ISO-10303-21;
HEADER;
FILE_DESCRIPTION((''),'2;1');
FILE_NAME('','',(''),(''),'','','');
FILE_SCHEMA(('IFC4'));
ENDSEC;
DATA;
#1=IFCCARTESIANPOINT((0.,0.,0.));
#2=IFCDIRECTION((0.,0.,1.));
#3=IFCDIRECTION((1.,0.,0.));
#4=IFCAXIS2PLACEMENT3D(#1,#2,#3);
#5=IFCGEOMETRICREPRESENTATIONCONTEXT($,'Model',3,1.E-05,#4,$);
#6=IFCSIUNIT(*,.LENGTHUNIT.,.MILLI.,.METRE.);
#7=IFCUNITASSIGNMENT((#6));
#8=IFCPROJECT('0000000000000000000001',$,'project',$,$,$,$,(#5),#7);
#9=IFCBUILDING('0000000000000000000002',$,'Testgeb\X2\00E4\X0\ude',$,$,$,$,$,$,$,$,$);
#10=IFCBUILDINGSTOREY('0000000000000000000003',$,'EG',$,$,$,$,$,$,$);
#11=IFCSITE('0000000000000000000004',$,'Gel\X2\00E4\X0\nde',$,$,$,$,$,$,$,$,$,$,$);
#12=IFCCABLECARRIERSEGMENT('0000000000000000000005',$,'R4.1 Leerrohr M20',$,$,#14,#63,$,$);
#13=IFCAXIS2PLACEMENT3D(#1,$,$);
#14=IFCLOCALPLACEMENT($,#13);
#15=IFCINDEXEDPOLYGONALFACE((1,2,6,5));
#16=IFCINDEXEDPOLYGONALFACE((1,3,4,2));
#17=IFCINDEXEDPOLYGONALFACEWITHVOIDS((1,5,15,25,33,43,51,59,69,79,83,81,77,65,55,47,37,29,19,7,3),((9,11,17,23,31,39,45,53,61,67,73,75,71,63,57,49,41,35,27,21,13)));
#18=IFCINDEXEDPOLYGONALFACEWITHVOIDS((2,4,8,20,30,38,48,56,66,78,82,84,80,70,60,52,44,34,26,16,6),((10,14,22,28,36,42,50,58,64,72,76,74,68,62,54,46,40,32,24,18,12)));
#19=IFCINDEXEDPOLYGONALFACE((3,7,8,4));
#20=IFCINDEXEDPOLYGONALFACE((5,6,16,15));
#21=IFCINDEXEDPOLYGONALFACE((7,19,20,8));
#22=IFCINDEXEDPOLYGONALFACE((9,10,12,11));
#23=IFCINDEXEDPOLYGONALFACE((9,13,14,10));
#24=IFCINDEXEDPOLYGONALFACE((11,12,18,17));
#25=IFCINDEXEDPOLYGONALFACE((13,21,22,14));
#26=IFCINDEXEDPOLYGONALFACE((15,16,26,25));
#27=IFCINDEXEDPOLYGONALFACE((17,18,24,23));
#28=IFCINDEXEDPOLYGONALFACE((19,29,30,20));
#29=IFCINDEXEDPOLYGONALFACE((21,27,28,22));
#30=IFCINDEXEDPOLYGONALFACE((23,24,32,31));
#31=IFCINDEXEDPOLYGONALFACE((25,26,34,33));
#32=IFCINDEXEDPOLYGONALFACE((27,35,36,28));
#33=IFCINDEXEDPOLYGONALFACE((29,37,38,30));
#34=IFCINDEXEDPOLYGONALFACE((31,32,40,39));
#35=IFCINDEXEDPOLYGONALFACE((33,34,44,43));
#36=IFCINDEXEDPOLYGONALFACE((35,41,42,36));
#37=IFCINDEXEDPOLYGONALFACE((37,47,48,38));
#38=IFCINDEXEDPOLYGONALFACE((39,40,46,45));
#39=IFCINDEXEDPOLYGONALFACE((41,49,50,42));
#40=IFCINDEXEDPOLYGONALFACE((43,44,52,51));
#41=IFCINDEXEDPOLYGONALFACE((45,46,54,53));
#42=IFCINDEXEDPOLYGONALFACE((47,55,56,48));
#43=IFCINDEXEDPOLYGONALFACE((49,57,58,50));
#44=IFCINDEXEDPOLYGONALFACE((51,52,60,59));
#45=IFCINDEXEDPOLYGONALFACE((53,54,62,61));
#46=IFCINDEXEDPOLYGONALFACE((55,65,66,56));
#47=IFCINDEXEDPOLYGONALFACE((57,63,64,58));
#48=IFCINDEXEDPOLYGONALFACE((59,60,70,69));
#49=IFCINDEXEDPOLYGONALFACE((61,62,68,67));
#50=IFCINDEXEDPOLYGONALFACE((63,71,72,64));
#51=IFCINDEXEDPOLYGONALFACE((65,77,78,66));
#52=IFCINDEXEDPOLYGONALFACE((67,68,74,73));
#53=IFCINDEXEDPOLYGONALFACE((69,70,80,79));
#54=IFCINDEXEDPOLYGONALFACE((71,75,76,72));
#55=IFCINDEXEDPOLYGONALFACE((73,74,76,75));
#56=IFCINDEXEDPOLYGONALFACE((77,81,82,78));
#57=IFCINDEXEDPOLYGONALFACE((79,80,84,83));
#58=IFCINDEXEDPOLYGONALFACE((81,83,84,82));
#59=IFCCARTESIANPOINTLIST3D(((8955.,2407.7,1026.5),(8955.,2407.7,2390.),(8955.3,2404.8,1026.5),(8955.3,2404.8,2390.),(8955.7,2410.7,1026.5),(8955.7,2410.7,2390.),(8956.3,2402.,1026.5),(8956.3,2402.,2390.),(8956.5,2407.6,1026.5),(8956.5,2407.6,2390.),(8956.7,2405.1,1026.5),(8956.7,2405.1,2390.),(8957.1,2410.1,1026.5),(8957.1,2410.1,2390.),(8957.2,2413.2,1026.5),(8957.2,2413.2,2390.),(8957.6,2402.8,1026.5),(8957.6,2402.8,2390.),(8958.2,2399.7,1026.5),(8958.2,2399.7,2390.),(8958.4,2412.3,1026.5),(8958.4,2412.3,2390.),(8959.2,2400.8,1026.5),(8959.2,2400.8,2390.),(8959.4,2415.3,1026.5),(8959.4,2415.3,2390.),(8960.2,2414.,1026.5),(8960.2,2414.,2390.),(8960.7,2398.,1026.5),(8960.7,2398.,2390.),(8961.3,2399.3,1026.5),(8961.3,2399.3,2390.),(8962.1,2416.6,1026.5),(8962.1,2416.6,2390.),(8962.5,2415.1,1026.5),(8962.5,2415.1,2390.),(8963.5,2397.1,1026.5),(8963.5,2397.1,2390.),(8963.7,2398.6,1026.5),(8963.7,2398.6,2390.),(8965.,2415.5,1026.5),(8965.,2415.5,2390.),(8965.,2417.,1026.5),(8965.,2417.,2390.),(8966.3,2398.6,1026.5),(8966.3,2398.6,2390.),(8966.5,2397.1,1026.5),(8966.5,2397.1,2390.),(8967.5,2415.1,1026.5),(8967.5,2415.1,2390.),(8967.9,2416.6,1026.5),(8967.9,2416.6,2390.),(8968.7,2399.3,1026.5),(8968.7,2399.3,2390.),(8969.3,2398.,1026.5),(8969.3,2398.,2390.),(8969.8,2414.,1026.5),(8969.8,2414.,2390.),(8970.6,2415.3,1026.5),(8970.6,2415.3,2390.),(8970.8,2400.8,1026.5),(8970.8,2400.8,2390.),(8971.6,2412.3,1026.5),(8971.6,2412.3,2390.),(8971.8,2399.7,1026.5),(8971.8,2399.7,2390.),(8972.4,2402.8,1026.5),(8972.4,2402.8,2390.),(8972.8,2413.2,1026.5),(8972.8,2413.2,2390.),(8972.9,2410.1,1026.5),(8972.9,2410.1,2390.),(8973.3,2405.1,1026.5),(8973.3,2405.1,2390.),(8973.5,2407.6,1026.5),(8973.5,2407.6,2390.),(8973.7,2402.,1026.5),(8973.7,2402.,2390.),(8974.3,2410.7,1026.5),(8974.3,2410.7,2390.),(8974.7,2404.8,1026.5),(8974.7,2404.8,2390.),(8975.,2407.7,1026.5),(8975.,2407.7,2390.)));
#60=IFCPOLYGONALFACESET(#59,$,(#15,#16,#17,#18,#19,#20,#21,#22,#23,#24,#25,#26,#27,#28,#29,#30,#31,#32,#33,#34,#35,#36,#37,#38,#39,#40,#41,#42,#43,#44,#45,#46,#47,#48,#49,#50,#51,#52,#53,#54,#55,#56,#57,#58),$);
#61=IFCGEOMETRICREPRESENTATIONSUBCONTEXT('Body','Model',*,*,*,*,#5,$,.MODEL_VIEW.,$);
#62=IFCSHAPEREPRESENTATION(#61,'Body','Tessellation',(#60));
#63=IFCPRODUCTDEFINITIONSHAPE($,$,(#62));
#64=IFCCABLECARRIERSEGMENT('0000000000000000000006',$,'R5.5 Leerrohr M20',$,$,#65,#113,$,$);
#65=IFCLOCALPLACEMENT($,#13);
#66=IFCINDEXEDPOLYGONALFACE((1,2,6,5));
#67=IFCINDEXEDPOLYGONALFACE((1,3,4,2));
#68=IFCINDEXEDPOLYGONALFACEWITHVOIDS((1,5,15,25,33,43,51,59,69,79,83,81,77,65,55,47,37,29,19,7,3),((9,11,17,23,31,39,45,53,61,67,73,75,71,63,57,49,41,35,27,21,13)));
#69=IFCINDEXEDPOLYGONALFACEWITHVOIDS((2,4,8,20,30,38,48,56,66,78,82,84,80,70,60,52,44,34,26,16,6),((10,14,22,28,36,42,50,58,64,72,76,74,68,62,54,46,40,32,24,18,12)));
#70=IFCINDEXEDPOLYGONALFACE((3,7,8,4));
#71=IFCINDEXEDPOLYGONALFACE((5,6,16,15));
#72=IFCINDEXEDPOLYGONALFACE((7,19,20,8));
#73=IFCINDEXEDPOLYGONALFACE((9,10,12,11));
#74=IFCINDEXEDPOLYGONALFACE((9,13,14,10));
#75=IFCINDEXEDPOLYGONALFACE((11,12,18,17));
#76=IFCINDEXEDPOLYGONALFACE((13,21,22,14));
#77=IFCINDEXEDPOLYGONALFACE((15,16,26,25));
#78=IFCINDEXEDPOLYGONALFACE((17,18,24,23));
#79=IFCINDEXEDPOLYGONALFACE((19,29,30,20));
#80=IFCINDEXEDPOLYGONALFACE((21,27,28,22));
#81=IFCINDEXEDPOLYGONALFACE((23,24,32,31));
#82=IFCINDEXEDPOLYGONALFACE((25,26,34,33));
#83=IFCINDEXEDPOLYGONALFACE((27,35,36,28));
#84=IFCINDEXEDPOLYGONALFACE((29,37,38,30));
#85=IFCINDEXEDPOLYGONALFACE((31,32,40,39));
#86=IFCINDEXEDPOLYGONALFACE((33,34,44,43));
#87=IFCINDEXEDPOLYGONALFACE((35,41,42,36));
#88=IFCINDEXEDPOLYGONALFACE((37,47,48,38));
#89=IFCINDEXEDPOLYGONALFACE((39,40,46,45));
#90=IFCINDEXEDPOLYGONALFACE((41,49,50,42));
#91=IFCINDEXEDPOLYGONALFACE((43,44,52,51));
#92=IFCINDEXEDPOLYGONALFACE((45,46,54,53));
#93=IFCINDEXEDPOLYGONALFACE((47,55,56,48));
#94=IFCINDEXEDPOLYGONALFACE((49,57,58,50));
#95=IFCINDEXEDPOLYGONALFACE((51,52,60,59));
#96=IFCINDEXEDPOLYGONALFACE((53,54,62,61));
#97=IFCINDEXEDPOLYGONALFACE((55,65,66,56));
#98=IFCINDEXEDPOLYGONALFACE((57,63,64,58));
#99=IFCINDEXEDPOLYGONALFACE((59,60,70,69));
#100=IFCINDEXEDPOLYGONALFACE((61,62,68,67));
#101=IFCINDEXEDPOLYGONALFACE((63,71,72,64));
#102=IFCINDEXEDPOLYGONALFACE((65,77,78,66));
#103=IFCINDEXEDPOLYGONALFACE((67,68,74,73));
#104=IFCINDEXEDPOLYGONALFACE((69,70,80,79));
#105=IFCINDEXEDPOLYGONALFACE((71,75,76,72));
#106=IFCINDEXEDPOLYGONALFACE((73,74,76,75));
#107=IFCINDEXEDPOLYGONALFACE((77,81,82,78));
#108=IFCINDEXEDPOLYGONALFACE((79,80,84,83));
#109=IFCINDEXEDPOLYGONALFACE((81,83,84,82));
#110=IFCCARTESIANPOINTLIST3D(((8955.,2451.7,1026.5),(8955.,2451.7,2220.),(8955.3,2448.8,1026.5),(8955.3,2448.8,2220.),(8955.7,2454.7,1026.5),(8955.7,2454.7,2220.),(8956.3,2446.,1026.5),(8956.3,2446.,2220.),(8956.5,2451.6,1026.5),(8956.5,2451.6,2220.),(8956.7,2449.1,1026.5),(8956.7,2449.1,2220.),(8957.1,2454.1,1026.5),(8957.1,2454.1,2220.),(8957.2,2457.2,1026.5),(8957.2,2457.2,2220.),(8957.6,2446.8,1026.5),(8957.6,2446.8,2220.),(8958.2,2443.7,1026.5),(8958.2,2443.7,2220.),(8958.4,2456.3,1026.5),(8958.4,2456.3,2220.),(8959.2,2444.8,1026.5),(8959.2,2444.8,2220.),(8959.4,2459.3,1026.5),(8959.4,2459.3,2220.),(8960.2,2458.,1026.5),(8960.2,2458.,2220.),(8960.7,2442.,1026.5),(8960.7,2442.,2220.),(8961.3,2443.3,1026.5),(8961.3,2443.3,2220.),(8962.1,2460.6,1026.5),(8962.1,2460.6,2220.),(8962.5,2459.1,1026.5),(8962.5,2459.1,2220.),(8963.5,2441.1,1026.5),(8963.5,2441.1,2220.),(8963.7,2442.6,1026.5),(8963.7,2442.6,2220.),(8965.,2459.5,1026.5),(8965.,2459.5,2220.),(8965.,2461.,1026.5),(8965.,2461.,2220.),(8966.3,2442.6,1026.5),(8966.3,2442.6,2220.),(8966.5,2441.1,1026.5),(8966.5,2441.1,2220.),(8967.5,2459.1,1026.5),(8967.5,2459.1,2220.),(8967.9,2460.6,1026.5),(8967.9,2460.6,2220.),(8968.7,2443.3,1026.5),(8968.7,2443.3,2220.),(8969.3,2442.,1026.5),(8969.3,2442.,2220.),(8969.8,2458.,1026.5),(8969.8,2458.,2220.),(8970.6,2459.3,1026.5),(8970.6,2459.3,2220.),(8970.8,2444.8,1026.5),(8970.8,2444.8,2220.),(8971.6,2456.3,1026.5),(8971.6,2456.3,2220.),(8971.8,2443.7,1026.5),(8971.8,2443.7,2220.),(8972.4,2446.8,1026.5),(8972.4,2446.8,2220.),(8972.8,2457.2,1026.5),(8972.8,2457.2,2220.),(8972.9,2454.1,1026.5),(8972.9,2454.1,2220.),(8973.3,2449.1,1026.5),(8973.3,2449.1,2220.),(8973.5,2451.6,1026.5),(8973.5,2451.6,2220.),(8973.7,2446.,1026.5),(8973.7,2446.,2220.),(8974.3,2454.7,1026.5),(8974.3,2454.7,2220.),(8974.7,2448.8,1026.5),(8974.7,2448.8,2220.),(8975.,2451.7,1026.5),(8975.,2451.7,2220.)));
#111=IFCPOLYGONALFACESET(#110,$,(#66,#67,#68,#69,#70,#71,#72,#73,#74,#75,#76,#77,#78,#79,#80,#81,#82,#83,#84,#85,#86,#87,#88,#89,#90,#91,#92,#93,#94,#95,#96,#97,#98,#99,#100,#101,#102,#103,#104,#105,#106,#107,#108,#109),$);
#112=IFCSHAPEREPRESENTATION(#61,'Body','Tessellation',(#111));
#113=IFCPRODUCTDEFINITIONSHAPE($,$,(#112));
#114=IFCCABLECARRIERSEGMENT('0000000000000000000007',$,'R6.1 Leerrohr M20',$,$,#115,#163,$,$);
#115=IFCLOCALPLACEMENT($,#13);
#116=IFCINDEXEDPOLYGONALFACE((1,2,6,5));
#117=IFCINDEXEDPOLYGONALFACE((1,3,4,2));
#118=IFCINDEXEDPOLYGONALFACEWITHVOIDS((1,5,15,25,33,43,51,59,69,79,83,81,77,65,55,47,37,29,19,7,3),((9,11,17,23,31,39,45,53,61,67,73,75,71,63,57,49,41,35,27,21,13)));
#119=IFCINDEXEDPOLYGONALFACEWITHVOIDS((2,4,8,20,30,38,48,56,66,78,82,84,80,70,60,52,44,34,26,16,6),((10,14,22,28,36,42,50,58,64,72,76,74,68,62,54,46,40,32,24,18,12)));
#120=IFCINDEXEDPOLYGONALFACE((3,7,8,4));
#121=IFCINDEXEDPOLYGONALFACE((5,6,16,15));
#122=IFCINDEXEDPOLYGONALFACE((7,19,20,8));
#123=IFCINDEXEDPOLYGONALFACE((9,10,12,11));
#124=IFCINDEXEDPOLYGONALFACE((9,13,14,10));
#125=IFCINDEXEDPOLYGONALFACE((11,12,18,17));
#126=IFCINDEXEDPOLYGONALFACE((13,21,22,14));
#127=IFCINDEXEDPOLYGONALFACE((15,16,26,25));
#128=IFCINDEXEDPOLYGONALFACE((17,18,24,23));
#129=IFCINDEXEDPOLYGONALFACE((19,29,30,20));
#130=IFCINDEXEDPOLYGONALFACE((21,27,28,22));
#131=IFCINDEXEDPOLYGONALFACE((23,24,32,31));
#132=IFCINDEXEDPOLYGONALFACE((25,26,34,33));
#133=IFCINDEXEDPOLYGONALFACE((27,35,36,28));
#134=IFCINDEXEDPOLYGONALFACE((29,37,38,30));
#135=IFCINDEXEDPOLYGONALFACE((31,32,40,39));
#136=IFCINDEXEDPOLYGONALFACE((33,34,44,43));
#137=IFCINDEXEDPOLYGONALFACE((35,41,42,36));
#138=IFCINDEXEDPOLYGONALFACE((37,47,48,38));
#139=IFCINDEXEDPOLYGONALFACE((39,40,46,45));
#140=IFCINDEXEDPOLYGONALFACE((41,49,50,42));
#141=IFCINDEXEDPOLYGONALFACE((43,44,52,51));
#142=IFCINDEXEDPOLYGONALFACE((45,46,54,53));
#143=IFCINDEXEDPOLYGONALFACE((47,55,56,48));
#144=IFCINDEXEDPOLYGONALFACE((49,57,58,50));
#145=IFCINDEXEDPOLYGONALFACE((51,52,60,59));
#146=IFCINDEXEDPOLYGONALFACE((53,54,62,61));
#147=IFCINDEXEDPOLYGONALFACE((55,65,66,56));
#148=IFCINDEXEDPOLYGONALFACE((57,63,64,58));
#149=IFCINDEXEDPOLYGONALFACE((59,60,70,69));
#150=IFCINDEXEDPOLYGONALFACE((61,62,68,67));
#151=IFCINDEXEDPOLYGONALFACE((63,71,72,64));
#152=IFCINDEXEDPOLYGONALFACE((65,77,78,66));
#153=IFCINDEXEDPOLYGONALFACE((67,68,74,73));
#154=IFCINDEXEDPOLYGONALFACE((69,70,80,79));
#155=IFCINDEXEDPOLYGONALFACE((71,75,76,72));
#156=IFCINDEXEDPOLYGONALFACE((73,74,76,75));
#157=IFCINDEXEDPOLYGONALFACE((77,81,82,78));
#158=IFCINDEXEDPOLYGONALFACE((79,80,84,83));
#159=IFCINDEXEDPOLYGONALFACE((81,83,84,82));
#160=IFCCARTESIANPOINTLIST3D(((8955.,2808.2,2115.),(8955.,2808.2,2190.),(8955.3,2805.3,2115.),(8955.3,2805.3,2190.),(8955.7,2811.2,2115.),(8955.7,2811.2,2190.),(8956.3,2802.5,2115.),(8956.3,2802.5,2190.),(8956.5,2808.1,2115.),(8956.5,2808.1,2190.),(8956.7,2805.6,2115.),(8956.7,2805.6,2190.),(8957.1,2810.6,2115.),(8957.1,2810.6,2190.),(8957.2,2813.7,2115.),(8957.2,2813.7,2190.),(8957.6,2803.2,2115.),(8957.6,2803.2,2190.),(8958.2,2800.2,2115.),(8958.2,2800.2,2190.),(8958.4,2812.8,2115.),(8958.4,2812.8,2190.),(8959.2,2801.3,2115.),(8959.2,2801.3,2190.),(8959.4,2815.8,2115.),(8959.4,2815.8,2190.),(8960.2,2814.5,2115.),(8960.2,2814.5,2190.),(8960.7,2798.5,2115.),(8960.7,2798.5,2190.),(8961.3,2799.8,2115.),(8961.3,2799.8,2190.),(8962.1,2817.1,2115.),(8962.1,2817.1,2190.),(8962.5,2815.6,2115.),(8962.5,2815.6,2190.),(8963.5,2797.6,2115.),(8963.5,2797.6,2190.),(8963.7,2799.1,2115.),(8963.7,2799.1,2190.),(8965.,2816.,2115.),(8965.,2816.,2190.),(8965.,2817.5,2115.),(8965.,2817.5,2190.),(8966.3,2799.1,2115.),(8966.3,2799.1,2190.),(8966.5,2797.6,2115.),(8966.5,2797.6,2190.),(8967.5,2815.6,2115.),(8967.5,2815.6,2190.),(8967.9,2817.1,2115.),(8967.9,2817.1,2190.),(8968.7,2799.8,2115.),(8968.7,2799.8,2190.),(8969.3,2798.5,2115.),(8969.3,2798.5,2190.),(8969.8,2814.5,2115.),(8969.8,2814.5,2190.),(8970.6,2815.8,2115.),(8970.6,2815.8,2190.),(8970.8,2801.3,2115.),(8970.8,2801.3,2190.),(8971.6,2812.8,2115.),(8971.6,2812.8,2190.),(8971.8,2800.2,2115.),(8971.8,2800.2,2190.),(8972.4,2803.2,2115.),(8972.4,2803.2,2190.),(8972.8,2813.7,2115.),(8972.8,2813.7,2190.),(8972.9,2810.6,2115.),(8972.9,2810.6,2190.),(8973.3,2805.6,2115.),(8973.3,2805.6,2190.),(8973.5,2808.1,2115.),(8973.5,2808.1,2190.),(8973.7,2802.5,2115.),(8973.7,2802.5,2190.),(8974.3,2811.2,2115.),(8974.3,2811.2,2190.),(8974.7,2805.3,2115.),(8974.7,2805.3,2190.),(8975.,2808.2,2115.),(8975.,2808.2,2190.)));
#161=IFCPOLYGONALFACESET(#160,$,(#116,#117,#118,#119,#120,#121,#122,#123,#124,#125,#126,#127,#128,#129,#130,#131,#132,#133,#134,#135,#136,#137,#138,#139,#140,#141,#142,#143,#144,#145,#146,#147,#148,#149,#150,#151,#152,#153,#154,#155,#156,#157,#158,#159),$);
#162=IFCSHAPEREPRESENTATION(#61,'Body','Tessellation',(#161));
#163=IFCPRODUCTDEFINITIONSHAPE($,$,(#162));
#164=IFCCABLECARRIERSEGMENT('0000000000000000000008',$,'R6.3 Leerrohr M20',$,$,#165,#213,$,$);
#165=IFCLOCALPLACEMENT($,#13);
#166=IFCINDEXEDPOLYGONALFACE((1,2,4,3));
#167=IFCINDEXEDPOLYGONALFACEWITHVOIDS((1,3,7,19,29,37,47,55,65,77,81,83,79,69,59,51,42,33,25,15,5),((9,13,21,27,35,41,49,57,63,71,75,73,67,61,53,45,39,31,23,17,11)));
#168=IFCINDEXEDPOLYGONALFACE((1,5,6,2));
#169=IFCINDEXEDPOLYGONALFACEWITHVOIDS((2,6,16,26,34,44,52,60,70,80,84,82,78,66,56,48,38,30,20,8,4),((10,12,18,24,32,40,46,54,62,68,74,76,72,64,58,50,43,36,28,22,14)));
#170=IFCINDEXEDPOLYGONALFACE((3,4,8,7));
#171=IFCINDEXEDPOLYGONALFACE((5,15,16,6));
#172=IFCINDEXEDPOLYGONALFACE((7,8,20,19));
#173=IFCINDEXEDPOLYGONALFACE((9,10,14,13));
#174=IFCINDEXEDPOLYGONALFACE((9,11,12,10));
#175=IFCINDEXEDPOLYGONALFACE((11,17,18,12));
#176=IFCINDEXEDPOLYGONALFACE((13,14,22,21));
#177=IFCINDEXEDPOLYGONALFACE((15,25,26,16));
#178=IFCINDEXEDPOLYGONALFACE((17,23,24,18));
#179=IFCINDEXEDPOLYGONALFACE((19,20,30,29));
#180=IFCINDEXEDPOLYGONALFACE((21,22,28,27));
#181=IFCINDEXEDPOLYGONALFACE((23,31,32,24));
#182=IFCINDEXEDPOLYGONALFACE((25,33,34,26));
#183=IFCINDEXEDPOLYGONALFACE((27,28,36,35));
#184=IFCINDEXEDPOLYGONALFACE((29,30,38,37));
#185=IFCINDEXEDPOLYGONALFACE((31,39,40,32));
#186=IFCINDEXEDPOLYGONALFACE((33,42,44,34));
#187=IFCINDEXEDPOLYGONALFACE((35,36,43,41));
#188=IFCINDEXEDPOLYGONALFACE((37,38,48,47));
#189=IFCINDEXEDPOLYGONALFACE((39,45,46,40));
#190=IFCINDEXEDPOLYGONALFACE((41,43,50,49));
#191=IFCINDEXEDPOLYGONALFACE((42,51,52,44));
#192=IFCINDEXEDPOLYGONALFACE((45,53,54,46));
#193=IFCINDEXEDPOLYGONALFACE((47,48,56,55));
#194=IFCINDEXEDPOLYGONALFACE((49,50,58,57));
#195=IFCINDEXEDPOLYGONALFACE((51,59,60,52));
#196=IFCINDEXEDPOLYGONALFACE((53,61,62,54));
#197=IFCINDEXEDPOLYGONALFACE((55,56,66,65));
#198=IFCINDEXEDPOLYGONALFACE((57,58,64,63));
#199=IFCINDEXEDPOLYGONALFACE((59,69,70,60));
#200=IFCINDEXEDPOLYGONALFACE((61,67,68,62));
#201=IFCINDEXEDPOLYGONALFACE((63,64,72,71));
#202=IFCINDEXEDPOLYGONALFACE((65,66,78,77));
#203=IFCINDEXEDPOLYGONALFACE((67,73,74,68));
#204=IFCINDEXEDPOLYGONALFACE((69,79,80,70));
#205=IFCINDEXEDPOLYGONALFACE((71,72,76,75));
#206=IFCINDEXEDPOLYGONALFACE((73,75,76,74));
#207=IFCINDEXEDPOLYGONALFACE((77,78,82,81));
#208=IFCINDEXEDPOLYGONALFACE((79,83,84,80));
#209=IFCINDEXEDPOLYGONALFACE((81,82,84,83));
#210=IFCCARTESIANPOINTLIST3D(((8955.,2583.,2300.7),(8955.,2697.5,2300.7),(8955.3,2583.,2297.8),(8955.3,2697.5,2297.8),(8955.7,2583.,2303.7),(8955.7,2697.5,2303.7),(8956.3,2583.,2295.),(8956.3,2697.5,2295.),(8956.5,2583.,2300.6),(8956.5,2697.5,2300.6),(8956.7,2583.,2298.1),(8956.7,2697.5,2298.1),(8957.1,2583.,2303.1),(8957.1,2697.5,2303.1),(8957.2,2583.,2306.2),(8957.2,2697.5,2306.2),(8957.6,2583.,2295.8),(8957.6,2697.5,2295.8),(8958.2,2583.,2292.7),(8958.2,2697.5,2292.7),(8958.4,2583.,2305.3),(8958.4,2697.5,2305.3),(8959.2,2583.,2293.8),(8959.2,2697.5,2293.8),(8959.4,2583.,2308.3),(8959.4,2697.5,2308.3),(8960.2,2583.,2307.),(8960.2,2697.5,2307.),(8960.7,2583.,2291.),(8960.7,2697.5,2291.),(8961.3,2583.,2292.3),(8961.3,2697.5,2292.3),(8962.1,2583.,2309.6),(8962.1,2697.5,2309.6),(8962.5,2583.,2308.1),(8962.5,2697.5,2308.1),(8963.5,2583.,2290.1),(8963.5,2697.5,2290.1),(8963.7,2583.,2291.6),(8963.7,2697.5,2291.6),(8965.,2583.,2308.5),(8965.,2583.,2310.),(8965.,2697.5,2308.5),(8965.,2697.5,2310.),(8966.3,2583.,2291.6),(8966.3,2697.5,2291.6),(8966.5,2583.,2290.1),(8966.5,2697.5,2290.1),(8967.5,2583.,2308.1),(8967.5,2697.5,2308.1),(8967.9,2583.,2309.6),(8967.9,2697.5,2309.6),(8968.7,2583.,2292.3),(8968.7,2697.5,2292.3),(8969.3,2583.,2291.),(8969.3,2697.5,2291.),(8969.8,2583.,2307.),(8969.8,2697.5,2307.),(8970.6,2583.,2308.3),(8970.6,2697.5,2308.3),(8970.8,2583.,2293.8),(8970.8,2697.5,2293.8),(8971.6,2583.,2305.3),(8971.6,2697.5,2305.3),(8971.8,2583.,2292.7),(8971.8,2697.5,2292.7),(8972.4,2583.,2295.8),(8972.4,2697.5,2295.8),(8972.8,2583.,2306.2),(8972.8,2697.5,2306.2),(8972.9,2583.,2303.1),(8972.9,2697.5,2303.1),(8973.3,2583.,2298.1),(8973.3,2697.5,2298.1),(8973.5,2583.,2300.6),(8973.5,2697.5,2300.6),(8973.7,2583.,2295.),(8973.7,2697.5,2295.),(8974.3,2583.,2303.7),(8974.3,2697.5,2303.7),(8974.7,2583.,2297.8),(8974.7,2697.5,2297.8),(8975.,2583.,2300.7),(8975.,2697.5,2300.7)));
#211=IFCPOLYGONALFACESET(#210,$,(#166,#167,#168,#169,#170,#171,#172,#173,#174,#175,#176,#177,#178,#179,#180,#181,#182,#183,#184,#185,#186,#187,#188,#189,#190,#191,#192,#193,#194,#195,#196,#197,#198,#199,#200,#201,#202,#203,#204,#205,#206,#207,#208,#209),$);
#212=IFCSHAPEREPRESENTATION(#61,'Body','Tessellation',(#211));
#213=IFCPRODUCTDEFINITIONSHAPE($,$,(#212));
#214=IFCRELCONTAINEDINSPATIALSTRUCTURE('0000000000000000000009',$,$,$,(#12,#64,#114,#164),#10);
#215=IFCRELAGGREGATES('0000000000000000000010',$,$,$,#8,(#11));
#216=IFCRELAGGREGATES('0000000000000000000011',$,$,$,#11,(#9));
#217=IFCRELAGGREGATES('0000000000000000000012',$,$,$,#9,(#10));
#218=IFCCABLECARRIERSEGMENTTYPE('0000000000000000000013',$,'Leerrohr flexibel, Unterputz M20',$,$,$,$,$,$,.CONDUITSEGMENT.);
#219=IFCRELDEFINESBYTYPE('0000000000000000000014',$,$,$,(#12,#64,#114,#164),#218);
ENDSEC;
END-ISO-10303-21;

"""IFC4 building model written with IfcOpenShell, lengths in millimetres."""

from ifc_helpers import new_model, si_unit, frame, origin_with_axes, place, context, subcontext, project, spatial, hollow_circle, extrude, type_object, element, save


model = new_model("IFC4")

# Units and contexts
model_context = context("Model", 3, precision=1e-05, world=origin_with_axes())
body_context = subcontext(model_context, "Body", "Model", "MODEL_VIEW")
ifc_project = project(units=[si_unit("LENGTHUNIT", "METRE", prefix="MILLI")], contexts=[model_context])

# Site, building, storey
site = spatial("IfcSite", under=ifc_project, Name="Gelände")
building = spatial("IfcBuilding", under=site, Name="Testgebäude")
storey = spatial("IfcBuildingStorey", under=building, Name="EG")

# Cable carrier segments
cable_carrier_segment_type_1 = type_object("IfcCableCarrierSegmentType", Name="Leerrohr flexibel, Unterputz M20", PredefinedType="CONDUITSEGMENT")
for number, where, z_axis, x_axis, name in (
    (1, (8965.0, 2407.0, 1026.5), (0.0, 0.0, 1.0), (0.0, 1.0, 0.0), "R4.1 Leerrohr M20"),
):
    element("IfcCableCarrierSegment", number, at=place(None, frame(where, z_axis=z_axis, x_axis=x_axis)), inside=storey, type_object=cable_carrier_segment_type_1, Name=name, context=body_context, shape_type="SweptSolid", body=[
        extrude(hollow_circle(Radius=10.0, WallThickness=1.5), None, (0.0, 0.0, 1.0), 1363.5),
    ])
cable_carrier_segment_1_placement = place(None, frame((8965.0, 2451.0, 2220.0), z_axis=(0.0, 0.0, -1.0), x_axis=(0.0, 1.0, 0.0)))
element("IfcCableCarrierSegment", 2, at=cable_carrier_segment_1_placement, inside=storey, type_object=cable_carrier_segment_type_1, Name="R5.5 Leerrohr M20", context=body_context, shape_type="SweptSolid", body=[
    extrude(hollow_circle(Radius=10.0, WallThickness=1.5), None, (0.0, 0.0, 1.0), 1193.5),
])
cable_carrier_segment_2_placement = place(None, frame((8965.0, 2807.5, 2115.0), z_axis=(0.0, 0.0, 1.0), x_axis=(0.0, 1.0, 0.0)))
element("IfcCableCarrierSegment", 3, at=cable_carrier_segment_2_placement, inside=storey, type_object=cable_carrier_segment_type_1, Name="R6.1 Leerrohr M20", context=body_context, shape_type="SweptSolid", body=[
    extrude(hollow_circle(Radius=10.0, WallThickness=1.5), None, (0.0, 0.0, 1.0), 75.0),
])
cable_carrier_segment_3_placement = place(None, frame((8965.0, 2697.5, 2300.0), z_axis=(0.0, -1.0, 0.0), x_axis=(0.0, 0.0, 1.0)))
element("IfcCableCarrierSegment", 4, at=cable_carrier_segment_3_placement, inside=storey, type_object=cable_carrier_segment_type_1, Name="R6.3 Leerrohr M20", context=body_context, shape_type="SweptSolid", body=[
    extrude(hollow_circle(Radius=10.0, WallThickness=1.5), None, (0.0, 0.0, 1.0), 114.5),
])

save(model, "model.ifc")
